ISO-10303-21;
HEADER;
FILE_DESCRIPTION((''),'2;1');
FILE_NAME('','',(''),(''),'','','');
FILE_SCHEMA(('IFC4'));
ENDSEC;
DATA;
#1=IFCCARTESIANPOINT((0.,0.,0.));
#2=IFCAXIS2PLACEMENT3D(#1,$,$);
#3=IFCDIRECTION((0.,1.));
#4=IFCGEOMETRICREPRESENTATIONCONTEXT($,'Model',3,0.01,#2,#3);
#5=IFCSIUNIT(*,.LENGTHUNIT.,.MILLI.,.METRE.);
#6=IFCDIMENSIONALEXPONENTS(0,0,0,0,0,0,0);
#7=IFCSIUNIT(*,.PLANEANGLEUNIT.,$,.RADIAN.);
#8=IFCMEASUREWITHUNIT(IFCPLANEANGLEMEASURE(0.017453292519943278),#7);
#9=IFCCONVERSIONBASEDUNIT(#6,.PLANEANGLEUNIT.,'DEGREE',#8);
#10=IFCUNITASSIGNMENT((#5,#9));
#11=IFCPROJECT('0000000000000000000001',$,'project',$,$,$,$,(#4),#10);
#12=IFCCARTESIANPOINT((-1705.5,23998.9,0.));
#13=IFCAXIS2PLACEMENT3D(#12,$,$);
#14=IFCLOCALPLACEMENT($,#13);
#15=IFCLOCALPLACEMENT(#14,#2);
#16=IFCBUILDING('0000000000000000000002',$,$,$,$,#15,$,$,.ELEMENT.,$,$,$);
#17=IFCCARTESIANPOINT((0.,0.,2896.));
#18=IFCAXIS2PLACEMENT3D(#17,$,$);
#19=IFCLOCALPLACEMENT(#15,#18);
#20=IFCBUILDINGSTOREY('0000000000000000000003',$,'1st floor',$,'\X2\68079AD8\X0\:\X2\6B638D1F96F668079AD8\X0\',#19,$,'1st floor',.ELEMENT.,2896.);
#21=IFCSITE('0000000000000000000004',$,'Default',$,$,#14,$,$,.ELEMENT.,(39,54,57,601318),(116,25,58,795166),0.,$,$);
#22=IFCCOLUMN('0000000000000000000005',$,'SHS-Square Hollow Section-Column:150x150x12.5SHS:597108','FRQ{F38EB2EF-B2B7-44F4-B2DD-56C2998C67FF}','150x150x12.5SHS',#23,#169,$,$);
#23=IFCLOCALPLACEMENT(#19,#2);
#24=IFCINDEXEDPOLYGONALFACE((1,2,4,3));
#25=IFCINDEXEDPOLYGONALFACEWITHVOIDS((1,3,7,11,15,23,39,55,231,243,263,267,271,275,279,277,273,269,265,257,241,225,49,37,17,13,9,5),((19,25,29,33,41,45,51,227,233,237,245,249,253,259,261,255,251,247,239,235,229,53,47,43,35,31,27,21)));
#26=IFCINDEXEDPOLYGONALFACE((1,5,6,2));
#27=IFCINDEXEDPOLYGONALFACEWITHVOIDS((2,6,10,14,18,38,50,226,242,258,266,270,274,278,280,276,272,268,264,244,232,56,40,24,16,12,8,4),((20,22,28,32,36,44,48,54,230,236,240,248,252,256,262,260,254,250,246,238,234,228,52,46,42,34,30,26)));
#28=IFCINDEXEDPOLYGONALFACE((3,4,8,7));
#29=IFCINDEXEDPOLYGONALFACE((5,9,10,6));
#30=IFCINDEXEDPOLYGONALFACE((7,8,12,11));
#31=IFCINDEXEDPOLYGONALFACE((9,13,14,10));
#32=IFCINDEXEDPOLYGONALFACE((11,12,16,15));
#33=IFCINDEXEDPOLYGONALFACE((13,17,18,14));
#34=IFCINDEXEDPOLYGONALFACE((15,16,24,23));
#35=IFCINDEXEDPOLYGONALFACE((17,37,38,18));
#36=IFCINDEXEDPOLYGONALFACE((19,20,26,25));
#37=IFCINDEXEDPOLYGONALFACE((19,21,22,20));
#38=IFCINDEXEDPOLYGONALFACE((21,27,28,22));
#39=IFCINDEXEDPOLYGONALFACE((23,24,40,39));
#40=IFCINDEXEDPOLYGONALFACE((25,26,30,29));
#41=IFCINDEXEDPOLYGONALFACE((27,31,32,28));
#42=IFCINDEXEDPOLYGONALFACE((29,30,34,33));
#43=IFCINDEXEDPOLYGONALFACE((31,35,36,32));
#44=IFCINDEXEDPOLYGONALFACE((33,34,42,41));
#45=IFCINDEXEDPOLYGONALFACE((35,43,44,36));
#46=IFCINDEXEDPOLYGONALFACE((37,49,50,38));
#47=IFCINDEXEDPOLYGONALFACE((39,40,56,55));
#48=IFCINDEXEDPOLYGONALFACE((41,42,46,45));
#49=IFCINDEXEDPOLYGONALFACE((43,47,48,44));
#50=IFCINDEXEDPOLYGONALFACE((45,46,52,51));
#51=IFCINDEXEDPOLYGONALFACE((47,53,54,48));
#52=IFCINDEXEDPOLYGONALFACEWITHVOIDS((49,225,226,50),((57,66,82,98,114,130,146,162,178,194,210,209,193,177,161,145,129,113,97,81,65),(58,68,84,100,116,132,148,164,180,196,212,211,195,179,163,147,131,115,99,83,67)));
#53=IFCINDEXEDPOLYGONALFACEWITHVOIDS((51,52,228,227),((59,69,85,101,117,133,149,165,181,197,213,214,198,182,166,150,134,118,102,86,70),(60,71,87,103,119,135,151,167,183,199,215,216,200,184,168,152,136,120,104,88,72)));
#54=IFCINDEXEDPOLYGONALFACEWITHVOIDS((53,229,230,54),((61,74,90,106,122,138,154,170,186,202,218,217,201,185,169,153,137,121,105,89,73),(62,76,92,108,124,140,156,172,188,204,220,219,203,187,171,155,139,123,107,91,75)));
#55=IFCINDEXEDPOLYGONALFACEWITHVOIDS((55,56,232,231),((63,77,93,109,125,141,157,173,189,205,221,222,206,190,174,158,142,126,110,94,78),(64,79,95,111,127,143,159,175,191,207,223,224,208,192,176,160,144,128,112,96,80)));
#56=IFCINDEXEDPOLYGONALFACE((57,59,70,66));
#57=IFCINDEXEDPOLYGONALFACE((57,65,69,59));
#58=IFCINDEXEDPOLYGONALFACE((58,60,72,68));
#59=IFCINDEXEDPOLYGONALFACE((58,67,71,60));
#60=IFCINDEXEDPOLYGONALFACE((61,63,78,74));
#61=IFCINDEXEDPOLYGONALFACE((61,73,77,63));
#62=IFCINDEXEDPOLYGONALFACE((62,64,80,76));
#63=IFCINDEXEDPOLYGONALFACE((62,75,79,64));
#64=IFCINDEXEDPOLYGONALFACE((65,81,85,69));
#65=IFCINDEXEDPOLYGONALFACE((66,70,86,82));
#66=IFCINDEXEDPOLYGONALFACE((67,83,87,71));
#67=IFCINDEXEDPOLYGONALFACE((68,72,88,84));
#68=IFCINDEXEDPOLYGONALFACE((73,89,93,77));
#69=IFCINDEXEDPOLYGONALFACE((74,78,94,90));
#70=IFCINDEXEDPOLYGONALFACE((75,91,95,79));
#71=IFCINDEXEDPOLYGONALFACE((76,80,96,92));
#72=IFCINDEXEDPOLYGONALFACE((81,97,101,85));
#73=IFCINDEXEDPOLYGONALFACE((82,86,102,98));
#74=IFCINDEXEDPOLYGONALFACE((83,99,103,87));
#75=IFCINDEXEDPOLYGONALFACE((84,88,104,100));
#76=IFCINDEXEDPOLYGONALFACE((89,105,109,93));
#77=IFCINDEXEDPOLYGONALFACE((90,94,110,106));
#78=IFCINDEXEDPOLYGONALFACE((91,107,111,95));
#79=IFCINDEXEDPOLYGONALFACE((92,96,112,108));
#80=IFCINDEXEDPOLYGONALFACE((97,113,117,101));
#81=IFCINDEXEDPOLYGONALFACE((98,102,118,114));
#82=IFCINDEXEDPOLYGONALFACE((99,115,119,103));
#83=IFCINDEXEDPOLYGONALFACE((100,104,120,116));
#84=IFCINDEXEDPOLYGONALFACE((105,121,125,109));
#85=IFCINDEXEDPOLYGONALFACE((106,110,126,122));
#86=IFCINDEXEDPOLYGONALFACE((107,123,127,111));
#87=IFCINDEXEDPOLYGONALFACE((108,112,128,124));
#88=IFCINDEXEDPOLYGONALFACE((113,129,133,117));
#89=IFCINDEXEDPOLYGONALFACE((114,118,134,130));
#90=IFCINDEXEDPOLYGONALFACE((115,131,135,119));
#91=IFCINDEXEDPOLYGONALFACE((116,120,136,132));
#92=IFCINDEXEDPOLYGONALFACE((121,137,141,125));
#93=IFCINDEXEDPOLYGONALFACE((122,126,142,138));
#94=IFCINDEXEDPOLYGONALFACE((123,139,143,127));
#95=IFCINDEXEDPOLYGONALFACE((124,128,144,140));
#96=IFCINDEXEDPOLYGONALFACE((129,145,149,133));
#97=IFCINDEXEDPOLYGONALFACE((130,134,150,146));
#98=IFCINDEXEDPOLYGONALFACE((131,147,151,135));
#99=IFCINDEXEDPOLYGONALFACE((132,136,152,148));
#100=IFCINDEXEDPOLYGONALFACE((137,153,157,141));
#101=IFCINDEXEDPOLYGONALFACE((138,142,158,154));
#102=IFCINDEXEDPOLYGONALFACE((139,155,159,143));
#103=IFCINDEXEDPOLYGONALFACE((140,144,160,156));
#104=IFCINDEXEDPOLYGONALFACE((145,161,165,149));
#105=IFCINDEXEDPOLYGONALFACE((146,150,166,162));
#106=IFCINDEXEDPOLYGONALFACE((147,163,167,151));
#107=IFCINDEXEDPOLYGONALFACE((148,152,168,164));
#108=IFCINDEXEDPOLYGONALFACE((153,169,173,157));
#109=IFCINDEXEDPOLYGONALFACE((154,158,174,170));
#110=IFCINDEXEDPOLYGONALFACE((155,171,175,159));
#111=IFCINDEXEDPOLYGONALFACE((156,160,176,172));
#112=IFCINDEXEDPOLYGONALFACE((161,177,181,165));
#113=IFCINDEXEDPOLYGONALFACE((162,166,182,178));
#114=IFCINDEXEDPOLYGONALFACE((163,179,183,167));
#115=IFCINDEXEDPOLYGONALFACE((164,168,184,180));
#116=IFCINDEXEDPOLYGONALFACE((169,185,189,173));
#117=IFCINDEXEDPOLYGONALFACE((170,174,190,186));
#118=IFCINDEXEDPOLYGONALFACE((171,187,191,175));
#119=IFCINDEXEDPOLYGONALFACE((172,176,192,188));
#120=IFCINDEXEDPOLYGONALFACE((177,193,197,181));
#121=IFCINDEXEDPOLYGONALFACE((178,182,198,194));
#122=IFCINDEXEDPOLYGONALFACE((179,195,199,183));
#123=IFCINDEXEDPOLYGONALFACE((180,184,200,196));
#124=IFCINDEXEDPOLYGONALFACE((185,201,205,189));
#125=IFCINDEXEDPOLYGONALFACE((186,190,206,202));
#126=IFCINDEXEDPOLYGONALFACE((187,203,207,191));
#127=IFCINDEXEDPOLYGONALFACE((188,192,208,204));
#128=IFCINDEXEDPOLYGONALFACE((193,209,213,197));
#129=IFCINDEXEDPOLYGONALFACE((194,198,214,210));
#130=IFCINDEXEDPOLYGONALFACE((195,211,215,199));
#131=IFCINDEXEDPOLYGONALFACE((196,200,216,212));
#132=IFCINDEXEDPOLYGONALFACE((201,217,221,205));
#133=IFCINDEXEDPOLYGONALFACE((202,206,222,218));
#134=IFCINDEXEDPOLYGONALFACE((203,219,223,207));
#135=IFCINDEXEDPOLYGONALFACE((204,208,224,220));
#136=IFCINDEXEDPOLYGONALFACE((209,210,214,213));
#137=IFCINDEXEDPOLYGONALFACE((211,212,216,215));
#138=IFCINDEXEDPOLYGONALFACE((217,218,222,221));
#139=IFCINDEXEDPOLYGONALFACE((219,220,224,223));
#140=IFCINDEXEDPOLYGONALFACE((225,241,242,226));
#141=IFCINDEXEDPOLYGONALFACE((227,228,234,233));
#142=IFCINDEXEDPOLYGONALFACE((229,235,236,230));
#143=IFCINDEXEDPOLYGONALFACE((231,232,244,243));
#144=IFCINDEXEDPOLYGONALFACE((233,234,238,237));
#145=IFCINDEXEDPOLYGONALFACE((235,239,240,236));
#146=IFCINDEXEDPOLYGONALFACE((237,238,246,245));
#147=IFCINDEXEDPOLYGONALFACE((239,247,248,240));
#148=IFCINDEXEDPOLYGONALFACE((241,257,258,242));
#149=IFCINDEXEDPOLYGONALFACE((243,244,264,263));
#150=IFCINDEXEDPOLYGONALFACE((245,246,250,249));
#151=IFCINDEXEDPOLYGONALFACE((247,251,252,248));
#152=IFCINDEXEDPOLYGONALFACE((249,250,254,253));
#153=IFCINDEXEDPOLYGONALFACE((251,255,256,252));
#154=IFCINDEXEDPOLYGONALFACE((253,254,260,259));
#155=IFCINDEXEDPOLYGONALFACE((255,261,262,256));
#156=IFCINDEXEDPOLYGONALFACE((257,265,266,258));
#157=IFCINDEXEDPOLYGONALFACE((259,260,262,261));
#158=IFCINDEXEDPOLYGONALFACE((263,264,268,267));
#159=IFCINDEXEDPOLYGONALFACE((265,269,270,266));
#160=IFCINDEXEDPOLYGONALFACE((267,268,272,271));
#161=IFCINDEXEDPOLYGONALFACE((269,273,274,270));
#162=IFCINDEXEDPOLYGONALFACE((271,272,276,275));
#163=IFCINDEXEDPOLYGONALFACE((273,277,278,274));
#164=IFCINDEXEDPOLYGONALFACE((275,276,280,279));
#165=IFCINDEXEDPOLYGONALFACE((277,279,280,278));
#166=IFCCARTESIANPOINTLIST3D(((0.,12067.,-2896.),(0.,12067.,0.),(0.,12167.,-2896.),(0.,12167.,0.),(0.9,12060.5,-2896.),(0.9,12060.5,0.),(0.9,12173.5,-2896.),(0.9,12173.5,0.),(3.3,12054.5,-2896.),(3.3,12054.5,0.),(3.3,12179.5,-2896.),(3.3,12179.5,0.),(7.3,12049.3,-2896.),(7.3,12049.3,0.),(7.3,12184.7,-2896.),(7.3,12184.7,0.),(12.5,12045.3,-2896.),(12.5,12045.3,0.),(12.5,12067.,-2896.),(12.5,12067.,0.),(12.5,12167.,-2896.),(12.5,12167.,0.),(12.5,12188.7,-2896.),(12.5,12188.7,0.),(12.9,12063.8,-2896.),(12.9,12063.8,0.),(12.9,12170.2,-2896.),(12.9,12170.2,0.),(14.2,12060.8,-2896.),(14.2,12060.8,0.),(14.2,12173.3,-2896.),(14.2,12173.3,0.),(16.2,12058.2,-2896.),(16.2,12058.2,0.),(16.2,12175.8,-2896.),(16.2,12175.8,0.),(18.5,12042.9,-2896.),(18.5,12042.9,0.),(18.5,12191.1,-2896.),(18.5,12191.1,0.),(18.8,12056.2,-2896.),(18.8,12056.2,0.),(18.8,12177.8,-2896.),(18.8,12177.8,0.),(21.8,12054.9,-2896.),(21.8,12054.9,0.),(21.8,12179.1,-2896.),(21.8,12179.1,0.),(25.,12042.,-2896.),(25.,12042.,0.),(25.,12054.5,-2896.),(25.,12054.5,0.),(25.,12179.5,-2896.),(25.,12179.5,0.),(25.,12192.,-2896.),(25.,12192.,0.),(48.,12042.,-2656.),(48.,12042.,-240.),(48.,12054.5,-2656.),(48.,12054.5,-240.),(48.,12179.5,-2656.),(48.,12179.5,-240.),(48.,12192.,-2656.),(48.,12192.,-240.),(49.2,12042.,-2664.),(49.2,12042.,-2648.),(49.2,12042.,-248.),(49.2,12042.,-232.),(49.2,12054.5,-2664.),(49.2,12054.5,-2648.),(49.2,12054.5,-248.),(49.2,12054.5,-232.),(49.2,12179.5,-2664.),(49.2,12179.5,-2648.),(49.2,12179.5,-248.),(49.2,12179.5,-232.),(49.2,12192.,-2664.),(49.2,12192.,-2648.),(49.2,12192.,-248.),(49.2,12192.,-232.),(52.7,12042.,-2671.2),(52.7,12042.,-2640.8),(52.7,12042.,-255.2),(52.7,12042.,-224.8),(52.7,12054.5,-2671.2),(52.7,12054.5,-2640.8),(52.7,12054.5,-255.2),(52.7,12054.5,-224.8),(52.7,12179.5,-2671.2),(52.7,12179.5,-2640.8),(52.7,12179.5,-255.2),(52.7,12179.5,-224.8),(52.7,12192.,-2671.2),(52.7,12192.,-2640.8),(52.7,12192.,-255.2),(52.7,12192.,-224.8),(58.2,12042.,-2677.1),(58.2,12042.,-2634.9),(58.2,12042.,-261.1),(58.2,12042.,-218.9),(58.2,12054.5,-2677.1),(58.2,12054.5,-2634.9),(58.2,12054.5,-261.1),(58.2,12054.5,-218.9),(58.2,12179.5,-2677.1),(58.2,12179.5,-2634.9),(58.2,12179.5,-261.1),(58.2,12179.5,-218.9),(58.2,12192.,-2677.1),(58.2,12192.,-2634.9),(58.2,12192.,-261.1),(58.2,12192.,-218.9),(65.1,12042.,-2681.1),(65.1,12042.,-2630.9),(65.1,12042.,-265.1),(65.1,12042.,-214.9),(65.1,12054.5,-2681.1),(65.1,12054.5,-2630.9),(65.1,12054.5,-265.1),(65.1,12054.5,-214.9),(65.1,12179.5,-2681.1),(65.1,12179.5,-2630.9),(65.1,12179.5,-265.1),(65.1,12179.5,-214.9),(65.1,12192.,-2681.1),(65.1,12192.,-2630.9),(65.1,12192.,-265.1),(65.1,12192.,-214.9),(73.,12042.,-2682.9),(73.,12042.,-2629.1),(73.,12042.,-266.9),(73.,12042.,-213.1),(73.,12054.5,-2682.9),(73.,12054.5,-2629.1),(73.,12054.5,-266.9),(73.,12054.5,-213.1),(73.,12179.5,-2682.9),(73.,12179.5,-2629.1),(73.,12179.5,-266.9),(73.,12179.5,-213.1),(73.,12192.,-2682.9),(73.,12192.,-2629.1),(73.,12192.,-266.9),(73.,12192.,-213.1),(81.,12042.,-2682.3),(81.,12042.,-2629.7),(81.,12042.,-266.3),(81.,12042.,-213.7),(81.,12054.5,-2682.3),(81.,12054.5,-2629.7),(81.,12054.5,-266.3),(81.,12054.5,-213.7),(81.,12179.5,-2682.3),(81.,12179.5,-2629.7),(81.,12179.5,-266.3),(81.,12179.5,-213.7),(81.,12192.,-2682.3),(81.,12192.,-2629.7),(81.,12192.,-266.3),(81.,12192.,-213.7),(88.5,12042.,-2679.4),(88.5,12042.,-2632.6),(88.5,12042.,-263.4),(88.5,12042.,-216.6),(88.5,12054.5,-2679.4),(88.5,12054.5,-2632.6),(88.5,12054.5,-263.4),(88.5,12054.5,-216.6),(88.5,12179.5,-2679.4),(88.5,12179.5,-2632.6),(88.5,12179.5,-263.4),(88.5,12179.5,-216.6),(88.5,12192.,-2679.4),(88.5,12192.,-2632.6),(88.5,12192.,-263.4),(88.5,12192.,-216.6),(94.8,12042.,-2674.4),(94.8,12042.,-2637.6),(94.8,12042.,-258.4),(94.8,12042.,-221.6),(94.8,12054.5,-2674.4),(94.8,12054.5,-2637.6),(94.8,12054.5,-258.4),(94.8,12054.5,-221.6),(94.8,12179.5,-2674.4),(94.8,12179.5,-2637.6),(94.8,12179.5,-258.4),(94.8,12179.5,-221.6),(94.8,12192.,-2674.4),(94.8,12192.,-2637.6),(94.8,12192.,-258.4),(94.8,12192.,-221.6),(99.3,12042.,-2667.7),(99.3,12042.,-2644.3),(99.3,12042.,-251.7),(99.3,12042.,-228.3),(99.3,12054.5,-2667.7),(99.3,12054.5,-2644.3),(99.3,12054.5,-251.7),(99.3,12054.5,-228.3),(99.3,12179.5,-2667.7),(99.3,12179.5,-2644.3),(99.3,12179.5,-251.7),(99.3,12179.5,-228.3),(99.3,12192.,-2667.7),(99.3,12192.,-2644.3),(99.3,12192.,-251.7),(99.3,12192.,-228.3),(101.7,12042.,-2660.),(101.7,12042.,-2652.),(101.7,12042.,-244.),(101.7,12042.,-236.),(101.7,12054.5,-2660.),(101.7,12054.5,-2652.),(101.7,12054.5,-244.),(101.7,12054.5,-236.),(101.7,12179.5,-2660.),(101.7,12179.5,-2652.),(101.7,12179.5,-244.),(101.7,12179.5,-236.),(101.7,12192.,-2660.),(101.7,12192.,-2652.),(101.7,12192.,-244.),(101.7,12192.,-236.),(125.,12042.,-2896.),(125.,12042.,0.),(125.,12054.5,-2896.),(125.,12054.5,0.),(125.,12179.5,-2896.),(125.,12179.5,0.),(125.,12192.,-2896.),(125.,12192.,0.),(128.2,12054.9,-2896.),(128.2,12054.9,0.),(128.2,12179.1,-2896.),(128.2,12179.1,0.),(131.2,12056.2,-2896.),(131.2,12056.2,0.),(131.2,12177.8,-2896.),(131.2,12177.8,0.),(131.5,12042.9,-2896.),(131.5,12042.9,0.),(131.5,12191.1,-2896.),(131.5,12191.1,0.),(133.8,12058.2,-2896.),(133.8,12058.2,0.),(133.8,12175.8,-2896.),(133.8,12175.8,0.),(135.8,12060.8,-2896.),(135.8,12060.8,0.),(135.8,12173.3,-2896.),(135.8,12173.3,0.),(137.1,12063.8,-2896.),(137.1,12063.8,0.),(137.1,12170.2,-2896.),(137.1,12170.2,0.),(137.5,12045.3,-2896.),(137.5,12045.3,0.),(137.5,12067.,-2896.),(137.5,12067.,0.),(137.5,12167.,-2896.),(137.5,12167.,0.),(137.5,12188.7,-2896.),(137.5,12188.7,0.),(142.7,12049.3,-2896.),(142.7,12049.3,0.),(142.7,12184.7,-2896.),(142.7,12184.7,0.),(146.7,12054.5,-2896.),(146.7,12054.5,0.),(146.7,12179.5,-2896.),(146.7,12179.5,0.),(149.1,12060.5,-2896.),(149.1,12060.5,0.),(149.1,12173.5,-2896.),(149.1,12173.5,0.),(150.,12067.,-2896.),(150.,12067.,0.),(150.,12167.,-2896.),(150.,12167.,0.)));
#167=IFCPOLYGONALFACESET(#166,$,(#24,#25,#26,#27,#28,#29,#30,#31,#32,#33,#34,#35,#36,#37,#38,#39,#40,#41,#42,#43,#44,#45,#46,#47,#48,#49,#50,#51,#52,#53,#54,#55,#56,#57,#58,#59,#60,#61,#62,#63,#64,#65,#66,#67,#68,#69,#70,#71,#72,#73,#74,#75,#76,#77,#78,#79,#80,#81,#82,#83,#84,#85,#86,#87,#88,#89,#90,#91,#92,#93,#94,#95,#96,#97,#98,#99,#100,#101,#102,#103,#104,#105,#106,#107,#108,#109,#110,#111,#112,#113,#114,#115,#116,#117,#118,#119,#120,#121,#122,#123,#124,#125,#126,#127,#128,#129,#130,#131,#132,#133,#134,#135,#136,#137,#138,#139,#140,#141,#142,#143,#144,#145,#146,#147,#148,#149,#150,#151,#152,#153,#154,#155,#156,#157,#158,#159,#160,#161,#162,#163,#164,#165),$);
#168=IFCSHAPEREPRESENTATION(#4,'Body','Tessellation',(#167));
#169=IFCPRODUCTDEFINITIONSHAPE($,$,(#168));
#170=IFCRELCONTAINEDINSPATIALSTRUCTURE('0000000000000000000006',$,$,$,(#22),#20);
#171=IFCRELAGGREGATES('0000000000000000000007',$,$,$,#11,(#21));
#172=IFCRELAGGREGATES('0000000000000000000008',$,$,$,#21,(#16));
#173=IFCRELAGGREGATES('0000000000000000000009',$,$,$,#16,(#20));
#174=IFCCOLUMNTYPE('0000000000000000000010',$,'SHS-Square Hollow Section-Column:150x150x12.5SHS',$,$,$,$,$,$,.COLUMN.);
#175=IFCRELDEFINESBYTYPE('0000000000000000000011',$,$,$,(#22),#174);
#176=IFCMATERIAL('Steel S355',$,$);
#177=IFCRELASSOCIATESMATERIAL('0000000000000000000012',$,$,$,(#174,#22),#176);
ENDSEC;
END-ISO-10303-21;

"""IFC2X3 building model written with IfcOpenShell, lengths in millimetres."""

from ifc_helpers import new_model, entity, si_unit, converted_unit, direction, frame, frame_2d, origin, origin_2d, place, context, project, spatial, circle_curve, hollow_rectangle, outline, extrude, material, type_object, element, save


model = new_model("IFC2X3")

# Units and contexts
model_context = context("Model", 3, precision=0.01, world=origin(), true_north=direction((0.0, 1.0)))
ifc_project = project(units=[si_unit("LENGTHUNIT", "METRE", prefix="MILLI"), converted_unit("PLANEANGLEUNIT", "DEGREE", entity("IfcPlaneAngleMeasure", 0.017453292519943278), si_unit("PLANEANGLEUNIT", "RADIAN"), dimensions=[0, 0, 0, 0, 0, 0, 0])], contexts=[model_context])

# Site, building, storey
site_placement = place(None, frame((-1705.5, 23998.9, 0.0)))
site = spatial("IfcSite", under=ifc_project, at=site_placement, Name="Default", CompositionType="ELEMENT", RefLatitude=(39, 54, 57, 601318), RefLongitude=(116, 25, 58, 795166), RefElevation=0.0)
building_placement = place(site_placement, origin())
building = spatial("IfcBuilding", under=site, at=building_placement, CompositionType="ELEMENT")
storey_placement = place(building_placement, frame((0.0, 0.0, 2896.0)))
storey = spatial("IfcBuildingStorey", under=building, at=storey_placement, Name="1st floor", ObjectType="标高:正负零标高", LongName="1st floor", CompositionType="ELEMENT", Elevation=2896.0)

# Shared definitions
ifc_material_1 = material(Name="Steel S355")

# Column, openings
column_type_1 = type_object("IfcColumnType", Name="SHS-Square Hollow Section-Column:150x150x12.5SHS", PredefinedType="COLUMN", material=ifc_material_1)
column_1_placement = place(storey_placement, frame((75.0, 12117.0, 0.0), z_axis=(0.0, 0.0, 1.0), x_axis=(0.0, -1.0, 0.0)))
column_1 = element("IfcColumn", 1, at=column_1_placement, inside=storey, type_object=column_type_1, material=ifc_material_1, Name="SHS-Square Hollow Section-Column:150x150x12.5SHS:597108", Description="FRQ{F38EB2EF-B2B7-44F4-B2DD-56C2998C67FF}", ObjectType="150x150x12.5SHS", context=model_context, shape_type="SweptSolid", body=[
    extrude(hollow_rectangle(XDim=150.0, YDim=150.0, WallThickness=12.5, InnerFilletRadius=12.5, OuterFilletRadius=25.0, at=origin_2d()), origin(), (0.0, 0.0, -1.0), 2896.0),
])
opening_1_placement = place(column_1_placement, frame((175.1, 0.0, -2896.0), z_axis=(-1.0, 0.0, 0.0), x_axis=(0.0, -1.0, 0.0)))
element("IfcOpeningElement", 2, at=opening_1_placement, cuts=column_1, ObjectType="Opening", context=model_context, shape_type="SweptSolid", body=[
    extrude(outline(circle_curve(frame_2d((0.0, 240.0), x_axis=(1.0, 0.0)), 27.0)), origin(), (0.0, 0.0, 1.0), 350.2),
])
opening_2_placement = place(column_1_placement, frame((175.1, 0.0, 0.0), z_axis=(-1.0, 0.0, 0.0), x_axis=(0.0, -1.0, 0.0)))
element("IfcOpeningElement", 3, at=opening_2_placement, cuts=column_1, ObjectType="Opening", context=model_context, shape_type="SweptSolid", body=[
    extrude(outline(circle_curve(frame_2d((0.0, -240.0), x_axis=(1.0, 0.0)), 27.0)), origin(), (0.0, 0.0, 1.0), 350.2),
])

save(model, "model.ifc")
